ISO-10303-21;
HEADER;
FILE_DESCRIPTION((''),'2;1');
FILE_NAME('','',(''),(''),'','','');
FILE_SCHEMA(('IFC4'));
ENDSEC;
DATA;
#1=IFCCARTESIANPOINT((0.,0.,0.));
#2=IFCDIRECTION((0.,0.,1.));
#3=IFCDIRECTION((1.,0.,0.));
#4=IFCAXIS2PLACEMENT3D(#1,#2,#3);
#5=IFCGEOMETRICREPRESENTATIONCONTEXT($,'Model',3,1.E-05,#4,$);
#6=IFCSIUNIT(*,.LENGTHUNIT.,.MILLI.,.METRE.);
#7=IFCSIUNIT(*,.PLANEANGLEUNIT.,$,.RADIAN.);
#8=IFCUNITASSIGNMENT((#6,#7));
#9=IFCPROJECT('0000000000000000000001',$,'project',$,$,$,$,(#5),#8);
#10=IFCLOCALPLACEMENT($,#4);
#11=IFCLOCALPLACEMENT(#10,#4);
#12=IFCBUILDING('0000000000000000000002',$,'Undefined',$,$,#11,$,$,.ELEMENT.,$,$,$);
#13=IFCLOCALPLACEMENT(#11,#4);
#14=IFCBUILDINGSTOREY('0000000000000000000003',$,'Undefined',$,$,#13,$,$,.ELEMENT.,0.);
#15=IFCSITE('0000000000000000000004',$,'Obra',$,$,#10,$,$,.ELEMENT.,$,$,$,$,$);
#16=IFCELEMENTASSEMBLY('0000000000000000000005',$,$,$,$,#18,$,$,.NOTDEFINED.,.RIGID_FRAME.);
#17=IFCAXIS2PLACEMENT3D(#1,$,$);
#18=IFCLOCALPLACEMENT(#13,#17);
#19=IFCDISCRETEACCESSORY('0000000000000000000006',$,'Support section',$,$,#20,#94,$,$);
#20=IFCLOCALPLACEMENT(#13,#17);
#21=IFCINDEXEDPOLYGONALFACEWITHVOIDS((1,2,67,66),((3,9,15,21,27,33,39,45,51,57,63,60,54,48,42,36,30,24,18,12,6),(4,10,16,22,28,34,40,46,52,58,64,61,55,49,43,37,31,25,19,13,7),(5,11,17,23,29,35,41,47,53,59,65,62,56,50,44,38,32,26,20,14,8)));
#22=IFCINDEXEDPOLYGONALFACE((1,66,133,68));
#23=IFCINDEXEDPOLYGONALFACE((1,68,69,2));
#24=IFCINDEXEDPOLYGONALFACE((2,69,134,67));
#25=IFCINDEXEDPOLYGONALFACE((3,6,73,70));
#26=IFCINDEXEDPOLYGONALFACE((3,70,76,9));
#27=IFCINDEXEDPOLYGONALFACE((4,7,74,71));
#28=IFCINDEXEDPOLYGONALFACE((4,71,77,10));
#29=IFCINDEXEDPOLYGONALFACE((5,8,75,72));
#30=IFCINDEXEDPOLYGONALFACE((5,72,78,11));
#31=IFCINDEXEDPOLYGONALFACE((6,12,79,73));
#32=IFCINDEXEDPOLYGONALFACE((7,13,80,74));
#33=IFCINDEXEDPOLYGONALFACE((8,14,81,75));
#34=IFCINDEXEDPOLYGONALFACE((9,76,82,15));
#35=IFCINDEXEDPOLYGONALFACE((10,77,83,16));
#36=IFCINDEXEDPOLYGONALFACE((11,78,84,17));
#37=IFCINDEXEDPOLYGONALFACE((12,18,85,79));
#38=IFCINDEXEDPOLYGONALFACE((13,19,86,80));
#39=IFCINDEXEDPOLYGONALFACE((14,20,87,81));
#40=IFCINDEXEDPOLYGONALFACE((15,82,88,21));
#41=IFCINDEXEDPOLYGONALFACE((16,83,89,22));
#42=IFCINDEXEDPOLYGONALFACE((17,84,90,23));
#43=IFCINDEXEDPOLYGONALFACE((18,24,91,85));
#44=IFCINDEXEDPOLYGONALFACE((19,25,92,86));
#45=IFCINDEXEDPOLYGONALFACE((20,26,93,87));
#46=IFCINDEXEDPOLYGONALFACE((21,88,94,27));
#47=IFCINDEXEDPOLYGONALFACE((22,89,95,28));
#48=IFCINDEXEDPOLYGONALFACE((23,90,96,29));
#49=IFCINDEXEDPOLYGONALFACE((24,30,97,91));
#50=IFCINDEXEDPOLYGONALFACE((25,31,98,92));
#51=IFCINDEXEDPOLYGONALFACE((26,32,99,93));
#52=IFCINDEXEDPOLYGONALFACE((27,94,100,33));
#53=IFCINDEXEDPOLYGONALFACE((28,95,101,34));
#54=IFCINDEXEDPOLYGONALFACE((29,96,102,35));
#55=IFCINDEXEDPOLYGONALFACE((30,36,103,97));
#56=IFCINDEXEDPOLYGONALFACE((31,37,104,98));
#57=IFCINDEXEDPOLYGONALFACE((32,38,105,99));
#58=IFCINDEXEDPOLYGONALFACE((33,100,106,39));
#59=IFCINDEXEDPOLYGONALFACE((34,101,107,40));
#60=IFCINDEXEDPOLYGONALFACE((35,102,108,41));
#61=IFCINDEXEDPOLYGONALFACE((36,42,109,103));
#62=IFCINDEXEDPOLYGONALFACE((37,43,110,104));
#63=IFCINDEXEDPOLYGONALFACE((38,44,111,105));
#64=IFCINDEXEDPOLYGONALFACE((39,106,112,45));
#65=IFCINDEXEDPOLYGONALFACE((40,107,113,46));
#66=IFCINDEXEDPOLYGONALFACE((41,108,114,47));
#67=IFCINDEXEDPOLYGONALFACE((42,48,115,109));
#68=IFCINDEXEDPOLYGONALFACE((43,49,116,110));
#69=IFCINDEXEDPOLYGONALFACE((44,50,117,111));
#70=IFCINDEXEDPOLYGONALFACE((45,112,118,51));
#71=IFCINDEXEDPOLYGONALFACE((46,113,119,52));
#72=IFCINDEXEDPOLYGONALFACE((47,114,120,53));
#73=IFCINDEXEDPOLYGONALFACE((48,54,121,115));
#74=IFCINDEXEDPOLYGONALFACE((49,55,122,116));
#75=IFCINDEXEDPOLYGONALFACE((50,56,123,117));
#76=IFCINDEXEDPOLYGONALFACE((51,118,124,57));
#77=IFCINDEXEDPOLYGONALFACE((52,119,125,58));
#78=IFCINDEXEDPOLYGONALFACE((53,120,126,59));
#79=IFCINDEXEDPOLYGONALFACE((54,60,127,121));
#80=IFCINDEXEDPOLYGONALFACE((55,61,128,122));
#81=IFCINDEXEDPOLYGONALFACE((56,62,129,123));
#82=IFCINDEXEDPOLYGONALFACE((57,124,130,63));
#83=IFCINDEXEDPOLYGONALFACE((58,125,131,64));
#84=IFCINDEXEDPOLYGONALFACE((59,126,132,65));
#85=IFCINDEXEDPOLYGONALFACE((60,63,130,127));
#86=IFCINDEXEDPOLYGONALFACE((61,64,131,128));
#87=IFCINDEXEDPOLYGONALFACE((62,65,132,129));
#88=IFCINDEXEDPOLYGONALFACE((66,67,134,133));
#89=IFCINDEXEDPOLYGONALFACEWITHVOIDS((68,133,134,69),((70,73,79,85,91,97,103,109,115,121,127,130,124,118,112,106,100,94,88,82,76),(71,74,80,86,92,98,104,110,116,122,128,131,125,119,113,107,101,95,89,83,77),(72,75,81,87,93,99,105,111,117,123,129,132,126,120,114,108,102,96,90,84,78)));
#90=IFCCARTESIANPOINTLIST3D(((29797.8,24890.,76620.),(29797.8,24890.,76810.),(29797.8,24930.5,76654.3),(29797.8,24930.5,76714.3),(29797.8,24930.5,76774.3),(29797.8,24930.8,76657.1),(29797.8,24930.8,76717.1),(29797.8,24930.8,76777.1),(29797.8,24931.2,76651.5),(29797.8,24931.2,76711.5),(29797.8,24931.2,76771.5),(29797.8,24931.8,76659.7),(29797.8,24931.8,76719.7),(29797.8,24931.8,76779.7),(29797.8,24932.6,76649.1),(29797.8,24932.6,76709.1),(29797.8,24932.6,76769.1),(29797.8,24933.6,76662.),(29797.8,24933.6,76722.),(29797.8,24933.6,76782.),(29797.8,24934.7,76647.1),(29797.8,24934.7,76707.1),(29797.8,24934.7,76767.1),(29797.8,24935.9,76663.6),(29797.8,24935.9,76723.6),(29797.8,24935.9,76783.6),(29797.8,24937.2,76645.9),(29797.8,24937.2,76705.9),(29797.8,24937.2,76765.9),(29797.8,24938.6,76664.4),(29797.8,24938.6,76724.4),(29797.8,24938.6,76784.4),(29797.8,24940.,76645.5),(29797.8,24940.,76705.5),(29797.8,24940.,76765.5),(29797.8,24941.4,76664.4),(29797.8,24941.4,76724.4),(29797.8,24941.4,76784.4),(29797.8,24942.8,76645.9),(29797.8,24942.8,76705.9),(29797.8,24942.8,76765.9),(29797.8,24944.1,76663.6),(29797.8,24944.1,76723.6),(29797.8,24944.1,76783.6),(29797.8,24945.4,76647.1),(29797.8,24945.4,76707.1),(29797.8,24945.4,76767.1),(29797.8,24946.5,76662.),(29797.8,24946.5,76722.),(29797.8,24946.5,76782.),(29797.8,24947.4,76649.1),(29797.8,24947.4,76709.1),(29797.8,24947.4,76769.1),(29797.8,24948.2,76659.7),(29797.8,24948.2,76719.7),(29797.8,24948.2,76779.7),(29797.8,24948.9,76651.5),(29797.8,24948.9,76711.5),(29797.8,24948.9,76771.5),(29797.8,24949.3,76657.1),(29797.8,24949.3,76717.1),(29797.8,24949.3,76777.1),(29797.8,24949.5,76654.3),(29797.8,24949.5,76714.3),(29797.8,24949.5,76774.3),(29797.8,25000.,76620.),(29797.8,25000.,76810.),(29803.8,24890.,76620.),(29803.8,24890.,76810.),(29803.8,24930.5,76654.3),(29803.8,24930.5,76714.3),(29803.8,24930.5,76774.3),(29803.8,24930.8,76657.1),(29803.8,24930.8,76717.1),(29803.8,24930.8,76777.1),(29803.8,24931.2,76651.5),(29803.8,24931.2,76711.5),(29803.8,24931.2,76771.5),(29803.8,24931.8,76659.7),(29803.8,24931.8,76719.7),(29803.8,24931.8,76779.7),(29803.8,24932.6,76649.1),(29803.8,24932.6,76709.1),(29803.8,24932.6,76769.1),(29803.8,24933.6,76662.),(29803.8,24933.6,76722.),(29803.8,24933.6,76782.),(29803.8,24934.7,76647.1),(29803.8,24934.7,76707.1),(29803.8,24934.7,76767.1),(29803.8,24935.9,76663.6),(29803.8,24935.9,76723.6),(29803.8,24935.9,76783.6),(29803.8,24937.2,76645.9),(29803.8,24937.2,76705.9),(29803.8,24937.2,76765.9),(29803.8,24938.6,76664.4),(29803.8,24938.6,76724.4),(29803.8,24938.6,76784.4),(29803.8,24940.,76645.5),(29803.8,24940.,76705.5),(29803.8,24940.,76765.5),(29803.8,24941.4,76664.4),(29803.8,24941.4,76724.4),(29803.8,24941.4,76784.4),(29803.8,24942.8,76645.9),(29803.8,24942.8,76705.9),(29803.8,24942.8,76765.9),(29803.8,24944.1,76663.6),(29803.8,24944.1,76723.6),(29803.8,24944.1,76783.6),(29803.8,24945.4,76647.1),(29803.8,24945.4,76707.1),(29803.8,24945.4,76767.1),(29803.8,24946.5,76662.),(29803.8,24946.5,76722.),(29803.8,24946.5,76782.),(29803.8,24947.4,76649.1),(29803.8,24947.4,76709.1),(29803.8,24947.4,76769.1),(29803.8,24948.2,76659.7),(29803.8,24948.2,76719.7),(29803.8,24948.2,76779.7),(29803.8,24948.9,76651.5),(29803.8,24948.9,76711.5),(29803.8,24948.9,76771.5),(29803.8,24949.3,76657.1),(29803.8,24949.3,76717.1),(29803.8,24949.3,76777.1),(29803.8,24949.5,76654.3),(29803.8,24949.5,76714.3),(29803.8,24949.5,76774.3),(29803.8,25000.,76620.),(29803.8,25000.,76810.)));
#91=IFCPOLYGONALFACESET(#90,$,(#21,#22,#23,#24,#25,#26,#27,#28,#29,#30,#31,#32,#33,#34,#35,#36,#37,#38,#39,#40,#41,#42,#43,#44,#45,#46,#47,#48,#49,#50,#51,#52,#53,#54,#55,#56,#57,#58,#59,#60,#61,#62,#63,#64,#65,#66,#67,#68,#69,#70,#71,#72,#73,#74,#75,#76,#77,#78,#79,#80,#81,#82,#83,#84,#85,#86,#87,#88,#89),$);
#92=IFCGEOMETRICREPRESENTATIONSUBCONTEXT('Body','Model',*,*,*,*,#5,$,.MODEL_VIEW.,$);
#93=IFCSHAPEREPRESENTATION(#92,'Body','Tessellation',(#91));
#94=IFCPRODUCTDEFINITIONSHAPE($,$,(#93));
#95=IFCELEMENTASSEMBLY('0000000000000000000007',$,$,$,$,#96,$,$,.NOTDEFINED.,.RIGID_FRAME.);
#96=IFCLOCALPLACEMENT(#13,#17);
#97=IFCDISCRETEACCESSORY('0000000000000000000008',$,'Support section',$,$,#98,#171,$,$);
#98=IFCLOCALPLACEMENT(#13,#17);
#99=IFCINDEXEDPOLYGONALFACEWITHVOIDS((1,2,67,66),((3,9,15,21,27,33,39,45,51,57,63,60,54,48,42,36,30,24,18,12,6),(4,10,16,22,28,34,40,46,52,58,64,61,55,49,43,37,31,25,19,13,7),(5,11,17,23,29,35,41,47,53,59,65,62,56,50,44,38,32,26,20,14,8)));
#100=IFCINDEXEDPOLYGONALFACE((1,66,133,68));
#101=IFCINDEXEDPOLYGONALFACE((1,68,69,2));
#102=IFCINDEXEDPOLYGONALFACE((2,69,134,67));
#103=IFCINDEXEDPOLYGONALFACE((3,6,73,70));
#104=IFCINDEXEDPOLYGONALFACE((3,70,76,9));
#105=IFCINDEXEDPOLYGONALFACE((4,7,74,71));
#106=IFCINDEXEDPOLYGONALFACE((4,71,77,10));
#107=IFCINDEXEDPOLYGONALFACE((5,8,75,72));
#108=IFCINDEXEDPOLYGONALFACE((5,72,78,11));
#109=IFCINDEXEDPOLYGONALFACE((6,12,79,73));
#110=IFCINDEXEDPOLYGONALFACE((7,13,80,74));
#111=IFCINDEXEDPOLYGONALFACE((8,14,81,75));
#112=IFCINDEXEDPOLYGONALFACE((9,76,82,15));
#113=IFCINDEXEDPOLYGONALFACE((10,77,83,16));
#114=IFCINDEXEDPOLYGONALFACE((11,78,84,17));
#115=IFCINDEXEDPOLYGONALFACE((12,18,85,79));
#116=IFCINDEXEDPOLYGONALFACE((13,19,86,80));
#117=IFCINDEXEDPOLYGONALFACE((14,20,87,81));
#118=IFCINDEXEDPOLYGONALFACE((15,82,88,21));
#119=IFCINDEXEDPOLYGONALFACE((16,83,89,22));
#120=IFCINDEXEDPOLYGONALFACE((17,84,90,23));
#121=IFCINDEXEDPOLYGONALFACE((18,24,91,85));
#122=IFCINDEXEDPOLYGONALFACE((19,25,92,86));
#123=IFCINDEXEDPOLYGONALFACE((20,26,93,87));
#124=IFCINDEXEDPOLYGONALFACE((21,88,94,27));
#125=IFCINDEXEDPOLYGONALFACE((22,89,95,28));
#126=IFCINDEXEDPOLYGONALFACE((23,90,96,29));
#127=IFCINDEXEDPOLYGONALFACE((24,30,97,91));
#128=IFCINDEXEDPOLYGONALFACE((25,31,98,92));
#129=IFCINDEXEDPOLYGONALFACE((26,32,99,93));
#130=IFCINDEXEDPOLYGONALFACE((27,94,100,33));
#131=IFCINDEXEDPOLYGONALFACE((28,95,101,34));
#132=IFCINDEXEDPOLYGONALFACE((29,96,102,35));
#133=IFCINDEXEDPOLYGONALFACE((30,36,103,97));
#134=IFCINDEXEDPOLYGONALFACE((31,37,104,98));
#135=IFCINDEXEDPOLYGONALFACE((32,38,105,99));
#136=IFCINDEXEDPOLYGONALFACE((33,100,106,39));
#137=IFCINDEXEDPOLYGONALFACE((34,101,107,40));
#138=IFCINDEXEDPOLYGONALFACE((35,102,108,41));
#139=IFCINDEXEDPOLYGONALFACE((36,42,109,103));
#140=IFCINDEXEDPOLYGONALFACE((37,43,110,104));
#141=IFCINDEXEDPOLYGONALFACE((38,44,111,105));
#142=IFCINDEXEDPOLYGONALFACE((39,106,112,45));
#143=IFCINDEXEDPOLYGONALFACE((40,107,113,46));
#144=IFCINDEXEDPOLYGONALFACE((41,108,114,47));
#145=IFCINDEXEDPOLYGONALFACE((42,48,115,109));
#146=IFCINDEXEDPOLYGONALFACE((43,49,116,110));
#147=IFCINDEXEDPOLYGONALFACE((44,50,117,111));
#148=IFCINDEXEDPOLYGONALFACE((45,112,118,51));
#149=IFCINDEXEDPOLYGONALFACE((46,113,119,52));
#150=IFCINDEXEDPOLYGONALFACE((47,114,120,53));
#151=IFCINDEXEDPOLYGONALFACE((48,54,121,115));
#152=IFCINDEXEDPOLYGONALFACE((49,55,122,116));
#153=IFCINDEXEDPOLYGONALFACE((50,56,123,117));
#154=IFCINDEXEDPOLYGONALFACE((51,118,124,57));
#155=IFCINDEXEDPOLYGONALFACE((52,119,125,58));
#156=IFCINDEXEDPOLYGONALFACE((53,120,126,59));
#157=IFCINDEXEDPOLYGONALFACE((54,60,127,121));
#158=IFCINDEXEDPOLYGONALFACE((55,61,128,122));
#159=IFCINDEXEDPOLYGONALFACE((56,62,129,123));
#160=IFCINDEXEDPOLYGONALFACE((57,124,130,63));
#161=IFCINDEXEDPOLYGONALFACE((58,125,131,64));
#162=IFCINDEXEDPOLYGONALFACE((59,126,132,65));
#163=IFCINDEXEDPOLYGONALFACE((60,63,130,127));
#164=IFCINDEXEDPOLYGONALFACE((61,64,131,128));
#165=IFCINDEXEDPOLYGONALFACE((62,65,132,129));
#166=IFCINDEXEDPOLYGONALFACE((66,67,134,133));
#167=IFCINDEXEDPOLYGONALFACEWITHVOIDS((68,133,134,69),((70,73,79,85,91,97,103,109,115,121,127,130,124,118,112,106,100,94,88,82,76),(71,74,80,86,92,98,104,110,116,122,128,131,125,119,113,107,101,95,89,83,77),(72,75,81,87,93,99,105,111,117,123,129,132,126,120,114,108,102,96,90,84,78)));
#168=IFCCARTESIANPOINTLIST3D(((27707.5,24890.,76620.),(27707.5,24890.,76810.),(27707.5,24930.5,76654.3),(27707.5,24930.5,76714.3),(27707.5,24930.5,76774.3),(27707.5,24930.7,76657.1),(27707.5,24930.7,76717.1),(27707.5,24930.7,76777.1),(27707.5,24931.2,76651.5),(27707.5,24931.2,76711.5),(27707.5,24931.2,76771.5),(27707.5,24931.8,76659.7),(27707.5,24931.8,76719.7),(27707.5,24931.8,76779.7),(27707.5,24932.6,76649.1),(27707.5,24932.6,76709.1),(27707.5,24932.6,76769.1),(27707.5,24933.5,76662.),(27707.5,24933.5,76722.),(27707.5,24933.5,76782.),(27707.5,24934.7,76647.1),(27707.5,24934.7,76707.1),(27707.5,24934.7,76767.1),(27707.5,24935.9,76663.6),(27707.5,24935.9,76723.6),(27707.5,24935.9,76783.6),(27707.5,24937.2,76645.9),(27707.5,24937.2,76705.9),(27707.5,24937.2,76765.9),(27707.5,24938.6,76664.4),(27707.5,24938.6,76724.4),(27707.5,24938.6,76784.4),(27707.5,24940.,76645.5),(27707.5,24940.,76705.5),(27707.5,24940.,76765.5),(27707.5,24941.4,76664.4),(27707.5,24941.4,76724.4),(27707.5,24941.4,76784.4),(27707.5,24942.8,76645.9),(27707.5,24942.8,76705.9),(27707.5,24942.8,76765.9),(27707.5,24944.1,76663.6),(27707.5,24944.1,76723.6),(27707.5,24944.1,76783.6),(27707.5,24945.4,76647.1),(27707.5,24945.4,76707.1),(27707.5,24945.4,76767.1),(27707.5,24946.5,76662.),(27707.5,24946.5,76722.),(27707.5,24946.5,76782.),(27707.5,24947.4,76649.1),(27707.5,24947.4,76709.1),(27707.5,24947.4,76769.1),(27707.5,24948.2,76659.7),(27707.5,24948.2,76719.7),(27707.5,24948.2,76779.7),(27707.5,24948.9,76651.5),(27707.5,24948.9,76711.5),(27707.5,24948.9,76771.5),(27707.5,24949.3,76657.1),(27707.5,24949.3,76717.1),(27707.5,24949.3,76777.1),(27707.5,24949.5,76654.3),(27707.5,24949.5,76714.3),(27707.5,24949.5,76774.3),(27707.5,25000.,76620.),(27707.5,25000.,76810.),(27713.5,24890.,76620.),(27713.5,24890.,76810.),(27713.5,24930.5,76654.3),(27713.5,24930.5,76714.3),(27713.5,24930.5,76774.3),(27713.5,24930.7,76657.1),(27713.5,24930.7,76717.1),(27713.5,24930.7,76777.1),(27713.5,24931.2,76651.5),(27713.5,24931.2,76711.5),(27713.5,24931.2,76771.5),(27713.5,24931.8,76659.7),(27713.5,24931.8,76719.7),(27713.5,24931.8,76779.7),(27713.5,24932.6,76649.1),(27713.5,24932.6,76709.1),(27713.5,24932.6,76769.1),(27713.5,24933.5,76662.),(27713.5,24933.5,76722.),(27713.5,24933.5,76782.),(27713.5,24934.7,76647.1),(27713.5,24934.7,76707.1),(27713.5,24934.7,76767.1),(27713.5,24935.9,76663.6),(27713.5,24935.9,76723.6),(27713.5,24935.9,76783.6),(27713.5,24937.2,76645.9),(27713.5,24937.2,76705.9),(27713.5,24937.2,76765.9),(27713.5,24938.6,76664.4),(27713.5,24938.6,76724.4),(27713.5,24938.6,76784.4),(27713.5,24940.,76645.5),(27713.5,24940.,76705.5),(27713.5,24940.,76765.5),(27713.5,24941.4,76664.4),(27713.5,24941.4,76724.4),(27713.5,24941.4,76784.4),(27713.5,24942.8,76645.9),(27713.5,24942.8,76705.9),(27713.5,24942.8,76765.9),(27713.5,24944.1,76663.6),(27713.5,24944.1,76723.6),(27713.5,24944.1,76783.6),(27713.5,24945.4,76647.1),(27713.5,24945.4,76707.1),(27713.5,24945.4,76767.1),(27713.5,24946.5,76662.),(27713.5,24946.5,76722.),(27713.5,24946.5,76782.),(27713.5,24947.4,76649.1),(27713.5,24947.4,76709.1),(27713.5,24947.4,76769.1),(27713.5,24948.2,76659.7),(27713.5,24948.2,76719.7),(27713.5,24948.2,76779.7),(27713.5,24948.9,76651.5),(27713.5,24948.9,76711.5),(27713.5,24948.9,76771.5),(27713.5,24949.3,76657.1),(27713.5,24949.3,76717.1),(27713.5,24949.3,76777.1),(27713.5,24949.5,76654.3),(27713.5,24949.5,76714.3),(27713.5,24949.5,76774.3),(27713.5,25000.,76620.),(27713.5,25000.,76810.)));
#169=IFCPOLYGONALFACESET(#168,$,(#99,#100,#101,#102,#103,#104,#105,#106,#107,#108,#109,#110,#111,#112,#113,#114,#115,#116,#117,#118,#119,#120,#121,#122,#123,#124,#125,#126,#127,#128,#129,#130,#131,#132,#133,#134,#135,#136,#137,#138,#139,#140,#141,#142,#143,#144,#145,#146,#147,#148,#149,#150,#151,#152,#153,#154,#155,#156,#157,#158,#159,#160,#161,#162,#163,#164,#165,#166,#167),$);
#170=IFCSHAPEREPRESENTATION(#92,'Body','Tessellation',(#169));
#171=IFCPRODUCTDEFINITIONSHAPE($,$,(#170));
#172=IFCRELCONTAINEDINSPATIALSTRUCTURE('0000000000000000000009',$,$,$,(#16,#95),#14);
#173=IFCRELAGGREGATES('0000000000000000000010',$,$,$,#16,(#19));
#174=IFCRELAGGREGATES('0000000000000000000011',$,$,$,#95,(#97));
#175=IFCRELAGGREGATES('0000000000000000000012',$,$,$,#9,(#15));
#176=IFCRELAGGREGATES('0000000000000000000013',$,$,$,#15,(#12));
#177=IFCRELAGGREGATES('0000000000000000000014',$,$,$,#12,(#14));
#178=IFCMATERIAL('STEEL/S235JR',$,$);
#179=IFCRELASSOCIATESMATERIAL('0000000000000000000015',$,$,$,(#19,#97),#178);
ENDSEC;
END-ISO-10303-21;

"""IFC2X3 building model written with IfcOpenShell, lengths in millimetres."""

from ifc_helpers import new_model, si_unit, frame, origin_with_axes, origin_2d_with_axis, place, context, subcontext, project, spatial, rectangle, circle, extrude, source, transform, mapped, material, element, aggregate, save


model = new_model("IFC2X3")

# Units and contexts
model_context = context("Model", 3, precision=1e-05, world=origin_with_axes())
body_context = subcontext(model_context, "Body", "Model", "MODEL_VIEW")
ifc_project = project(units=[si_unit("LENGTHUNIT", "METRE", prefix="MILLI"), si_unit("PLANEANGLEUNIT", "RADIAN")], contexts=[model_context])

# Site, building, storey
site_placement = place(None, origin_with_axes())
site = spatial("IfcSite", under=ifc_project, at=site_placement, Name="Obra", CompositionType="ELEMENT")
building_placement = place(site_placement, origin_with_axes())
building = spatial("IfcBuilding", under=site, at=building_placement, Name="Undefined", CompositionType="ELEMENT")
storey_placement = place(building_placement, origin_with_axes())
storey = spatial("IfcBuildingStorey", under=building, at=storey_placement, Name="Undefined", CompositionType="ELEMENT", Elevation=0.0)

# Shared definitions
ifc_material = material(Name="STEEL/S235JR")

# Element assemblies, discrete accessories, openings
assembly_1_placement = place(storey_placement, origin_with_axes())
assembly_1 = element("IfcElementAssembly", 1, at=assembly_1_placement, inside=storey, AssemblyPlace="NOTDEFINED", PredefinedType="RIGID_FRAME")
discrete_accessory_1_placement = place(assembly_1_placement, frame((29800.8, 24945.0, 76620.0), z_axis=(0.0, 0.0, 1.0), x_axis=(-0.000002, 1.0, 0.0)))
discrete_accessory_1 = element("IfcDiscreteAccessory", 2, at=discrete_accessory_1_placement, material=ifc_material, Name="Support section", context=body_context, shape_type="SweptSolid", body=[
    extrude(rectangle(XDim=6.0, YDim=110.0, at=origin_2d_with_axis()), frame((0.0, 0.0, 190.0), z_axis=(0.0, 0.0, -1.0), x_axis=(0.0, 1.0, 0.0)), (0.0, 0.0, 1.0), 190.0),
])
shared_shape_1 = source(origin_with_axes(), body_context, "Body", "SweptSolid", [
    extrude(circle(Radius=9.5, at=origin_2d_with_axis()), frame((0.0, -9.2, 0.0), z_axis=(0.0, 1.0, 0.0), x_axis=(1.0, 0.0, 0.0)), (0.0, 0.0, 1.0), 6.2),
])
opening_1_placement = place(assembly_1_placement, frame((29806.9, 24990.0, 76835.0), z_axis=(0.000002, -1.0, 0.0), x_axis=(0.0, 0.0, -1.0)))
element("IfcOpeningElement", 3, at=opening_1_placement, cuts=discrete_accessory_1, ObjectType="Opening", context=body_context, shape_type="MappedRepresentation", body=[
    mapped(shared_shape_1, transform((60.0, 0.0, 50.0))),
    mapped(shared_shape_1, transform((120.0, 0.0, 50.0))),
    mapped(shared_shape_1, transform((180.0, 0.0, 50.0))),
])
aggregate(assembly_1, [discrete_accessory_1])
assembly_2_placement = place(storey_placement, origin_with_axes())
assembly_2 = element("IfcElementAssembly", 4, at=assembly_2_placement, inside=storey, AssemblyPlace="NOTDEFINED", PredefinedType="RIGID_FRAME")
discrete_accessory_2_placement = place(assembly_2_placement, frame((27710.5, 24945.0, 76620.0), z_axis=(0.0, 0.0, 1.0), x_axis=(-0.000002, 1.0, 0.0)))
discrete_accessory_2 = element("IfcDiscreteAccessory", 5, at=discrete_accessory_2_placement, material=ifc_material, Name="Support section", context=body_context, shape_type="SweptSolid", body=[
    extrude(rectangle(XDim=6.0, YDim=110.0, at=origin_2d_with_axis()), frame((0.0, 0.0, 190.0), z_axis=(0.0, 0.0, -1.0), x_axis=(0.0, 1.0, 0.0)), (0.0, 0.0, 1.0), 190.0),
])
opening_2_placement = place(assembly_2_placement, frame((27716.6, 24990.0, 76835.0), z_axis=(0.000002, -1.0, 0.0), x_axis=(0.0, 0.0, -1.0)))
element("IfcOpeningElement", 6, at=opening_2_placement, cuts=discrete_accessory_2, ObjectType="Opening", context=body_context, shape_type="MappedRepresentation", body=[
    mapped(shared_shape_1, transform((60.0, 0.0, 50.0))),
    mapped(shared_shape_1, transform((120.0, 0.0, 50.0))),
    mapped(shared_shape_1, transform((180.0, 0.0, 50.0))),
])
aggregate(assembly_2, [discrete_accessory_2])

save(model, "model.ifc")
